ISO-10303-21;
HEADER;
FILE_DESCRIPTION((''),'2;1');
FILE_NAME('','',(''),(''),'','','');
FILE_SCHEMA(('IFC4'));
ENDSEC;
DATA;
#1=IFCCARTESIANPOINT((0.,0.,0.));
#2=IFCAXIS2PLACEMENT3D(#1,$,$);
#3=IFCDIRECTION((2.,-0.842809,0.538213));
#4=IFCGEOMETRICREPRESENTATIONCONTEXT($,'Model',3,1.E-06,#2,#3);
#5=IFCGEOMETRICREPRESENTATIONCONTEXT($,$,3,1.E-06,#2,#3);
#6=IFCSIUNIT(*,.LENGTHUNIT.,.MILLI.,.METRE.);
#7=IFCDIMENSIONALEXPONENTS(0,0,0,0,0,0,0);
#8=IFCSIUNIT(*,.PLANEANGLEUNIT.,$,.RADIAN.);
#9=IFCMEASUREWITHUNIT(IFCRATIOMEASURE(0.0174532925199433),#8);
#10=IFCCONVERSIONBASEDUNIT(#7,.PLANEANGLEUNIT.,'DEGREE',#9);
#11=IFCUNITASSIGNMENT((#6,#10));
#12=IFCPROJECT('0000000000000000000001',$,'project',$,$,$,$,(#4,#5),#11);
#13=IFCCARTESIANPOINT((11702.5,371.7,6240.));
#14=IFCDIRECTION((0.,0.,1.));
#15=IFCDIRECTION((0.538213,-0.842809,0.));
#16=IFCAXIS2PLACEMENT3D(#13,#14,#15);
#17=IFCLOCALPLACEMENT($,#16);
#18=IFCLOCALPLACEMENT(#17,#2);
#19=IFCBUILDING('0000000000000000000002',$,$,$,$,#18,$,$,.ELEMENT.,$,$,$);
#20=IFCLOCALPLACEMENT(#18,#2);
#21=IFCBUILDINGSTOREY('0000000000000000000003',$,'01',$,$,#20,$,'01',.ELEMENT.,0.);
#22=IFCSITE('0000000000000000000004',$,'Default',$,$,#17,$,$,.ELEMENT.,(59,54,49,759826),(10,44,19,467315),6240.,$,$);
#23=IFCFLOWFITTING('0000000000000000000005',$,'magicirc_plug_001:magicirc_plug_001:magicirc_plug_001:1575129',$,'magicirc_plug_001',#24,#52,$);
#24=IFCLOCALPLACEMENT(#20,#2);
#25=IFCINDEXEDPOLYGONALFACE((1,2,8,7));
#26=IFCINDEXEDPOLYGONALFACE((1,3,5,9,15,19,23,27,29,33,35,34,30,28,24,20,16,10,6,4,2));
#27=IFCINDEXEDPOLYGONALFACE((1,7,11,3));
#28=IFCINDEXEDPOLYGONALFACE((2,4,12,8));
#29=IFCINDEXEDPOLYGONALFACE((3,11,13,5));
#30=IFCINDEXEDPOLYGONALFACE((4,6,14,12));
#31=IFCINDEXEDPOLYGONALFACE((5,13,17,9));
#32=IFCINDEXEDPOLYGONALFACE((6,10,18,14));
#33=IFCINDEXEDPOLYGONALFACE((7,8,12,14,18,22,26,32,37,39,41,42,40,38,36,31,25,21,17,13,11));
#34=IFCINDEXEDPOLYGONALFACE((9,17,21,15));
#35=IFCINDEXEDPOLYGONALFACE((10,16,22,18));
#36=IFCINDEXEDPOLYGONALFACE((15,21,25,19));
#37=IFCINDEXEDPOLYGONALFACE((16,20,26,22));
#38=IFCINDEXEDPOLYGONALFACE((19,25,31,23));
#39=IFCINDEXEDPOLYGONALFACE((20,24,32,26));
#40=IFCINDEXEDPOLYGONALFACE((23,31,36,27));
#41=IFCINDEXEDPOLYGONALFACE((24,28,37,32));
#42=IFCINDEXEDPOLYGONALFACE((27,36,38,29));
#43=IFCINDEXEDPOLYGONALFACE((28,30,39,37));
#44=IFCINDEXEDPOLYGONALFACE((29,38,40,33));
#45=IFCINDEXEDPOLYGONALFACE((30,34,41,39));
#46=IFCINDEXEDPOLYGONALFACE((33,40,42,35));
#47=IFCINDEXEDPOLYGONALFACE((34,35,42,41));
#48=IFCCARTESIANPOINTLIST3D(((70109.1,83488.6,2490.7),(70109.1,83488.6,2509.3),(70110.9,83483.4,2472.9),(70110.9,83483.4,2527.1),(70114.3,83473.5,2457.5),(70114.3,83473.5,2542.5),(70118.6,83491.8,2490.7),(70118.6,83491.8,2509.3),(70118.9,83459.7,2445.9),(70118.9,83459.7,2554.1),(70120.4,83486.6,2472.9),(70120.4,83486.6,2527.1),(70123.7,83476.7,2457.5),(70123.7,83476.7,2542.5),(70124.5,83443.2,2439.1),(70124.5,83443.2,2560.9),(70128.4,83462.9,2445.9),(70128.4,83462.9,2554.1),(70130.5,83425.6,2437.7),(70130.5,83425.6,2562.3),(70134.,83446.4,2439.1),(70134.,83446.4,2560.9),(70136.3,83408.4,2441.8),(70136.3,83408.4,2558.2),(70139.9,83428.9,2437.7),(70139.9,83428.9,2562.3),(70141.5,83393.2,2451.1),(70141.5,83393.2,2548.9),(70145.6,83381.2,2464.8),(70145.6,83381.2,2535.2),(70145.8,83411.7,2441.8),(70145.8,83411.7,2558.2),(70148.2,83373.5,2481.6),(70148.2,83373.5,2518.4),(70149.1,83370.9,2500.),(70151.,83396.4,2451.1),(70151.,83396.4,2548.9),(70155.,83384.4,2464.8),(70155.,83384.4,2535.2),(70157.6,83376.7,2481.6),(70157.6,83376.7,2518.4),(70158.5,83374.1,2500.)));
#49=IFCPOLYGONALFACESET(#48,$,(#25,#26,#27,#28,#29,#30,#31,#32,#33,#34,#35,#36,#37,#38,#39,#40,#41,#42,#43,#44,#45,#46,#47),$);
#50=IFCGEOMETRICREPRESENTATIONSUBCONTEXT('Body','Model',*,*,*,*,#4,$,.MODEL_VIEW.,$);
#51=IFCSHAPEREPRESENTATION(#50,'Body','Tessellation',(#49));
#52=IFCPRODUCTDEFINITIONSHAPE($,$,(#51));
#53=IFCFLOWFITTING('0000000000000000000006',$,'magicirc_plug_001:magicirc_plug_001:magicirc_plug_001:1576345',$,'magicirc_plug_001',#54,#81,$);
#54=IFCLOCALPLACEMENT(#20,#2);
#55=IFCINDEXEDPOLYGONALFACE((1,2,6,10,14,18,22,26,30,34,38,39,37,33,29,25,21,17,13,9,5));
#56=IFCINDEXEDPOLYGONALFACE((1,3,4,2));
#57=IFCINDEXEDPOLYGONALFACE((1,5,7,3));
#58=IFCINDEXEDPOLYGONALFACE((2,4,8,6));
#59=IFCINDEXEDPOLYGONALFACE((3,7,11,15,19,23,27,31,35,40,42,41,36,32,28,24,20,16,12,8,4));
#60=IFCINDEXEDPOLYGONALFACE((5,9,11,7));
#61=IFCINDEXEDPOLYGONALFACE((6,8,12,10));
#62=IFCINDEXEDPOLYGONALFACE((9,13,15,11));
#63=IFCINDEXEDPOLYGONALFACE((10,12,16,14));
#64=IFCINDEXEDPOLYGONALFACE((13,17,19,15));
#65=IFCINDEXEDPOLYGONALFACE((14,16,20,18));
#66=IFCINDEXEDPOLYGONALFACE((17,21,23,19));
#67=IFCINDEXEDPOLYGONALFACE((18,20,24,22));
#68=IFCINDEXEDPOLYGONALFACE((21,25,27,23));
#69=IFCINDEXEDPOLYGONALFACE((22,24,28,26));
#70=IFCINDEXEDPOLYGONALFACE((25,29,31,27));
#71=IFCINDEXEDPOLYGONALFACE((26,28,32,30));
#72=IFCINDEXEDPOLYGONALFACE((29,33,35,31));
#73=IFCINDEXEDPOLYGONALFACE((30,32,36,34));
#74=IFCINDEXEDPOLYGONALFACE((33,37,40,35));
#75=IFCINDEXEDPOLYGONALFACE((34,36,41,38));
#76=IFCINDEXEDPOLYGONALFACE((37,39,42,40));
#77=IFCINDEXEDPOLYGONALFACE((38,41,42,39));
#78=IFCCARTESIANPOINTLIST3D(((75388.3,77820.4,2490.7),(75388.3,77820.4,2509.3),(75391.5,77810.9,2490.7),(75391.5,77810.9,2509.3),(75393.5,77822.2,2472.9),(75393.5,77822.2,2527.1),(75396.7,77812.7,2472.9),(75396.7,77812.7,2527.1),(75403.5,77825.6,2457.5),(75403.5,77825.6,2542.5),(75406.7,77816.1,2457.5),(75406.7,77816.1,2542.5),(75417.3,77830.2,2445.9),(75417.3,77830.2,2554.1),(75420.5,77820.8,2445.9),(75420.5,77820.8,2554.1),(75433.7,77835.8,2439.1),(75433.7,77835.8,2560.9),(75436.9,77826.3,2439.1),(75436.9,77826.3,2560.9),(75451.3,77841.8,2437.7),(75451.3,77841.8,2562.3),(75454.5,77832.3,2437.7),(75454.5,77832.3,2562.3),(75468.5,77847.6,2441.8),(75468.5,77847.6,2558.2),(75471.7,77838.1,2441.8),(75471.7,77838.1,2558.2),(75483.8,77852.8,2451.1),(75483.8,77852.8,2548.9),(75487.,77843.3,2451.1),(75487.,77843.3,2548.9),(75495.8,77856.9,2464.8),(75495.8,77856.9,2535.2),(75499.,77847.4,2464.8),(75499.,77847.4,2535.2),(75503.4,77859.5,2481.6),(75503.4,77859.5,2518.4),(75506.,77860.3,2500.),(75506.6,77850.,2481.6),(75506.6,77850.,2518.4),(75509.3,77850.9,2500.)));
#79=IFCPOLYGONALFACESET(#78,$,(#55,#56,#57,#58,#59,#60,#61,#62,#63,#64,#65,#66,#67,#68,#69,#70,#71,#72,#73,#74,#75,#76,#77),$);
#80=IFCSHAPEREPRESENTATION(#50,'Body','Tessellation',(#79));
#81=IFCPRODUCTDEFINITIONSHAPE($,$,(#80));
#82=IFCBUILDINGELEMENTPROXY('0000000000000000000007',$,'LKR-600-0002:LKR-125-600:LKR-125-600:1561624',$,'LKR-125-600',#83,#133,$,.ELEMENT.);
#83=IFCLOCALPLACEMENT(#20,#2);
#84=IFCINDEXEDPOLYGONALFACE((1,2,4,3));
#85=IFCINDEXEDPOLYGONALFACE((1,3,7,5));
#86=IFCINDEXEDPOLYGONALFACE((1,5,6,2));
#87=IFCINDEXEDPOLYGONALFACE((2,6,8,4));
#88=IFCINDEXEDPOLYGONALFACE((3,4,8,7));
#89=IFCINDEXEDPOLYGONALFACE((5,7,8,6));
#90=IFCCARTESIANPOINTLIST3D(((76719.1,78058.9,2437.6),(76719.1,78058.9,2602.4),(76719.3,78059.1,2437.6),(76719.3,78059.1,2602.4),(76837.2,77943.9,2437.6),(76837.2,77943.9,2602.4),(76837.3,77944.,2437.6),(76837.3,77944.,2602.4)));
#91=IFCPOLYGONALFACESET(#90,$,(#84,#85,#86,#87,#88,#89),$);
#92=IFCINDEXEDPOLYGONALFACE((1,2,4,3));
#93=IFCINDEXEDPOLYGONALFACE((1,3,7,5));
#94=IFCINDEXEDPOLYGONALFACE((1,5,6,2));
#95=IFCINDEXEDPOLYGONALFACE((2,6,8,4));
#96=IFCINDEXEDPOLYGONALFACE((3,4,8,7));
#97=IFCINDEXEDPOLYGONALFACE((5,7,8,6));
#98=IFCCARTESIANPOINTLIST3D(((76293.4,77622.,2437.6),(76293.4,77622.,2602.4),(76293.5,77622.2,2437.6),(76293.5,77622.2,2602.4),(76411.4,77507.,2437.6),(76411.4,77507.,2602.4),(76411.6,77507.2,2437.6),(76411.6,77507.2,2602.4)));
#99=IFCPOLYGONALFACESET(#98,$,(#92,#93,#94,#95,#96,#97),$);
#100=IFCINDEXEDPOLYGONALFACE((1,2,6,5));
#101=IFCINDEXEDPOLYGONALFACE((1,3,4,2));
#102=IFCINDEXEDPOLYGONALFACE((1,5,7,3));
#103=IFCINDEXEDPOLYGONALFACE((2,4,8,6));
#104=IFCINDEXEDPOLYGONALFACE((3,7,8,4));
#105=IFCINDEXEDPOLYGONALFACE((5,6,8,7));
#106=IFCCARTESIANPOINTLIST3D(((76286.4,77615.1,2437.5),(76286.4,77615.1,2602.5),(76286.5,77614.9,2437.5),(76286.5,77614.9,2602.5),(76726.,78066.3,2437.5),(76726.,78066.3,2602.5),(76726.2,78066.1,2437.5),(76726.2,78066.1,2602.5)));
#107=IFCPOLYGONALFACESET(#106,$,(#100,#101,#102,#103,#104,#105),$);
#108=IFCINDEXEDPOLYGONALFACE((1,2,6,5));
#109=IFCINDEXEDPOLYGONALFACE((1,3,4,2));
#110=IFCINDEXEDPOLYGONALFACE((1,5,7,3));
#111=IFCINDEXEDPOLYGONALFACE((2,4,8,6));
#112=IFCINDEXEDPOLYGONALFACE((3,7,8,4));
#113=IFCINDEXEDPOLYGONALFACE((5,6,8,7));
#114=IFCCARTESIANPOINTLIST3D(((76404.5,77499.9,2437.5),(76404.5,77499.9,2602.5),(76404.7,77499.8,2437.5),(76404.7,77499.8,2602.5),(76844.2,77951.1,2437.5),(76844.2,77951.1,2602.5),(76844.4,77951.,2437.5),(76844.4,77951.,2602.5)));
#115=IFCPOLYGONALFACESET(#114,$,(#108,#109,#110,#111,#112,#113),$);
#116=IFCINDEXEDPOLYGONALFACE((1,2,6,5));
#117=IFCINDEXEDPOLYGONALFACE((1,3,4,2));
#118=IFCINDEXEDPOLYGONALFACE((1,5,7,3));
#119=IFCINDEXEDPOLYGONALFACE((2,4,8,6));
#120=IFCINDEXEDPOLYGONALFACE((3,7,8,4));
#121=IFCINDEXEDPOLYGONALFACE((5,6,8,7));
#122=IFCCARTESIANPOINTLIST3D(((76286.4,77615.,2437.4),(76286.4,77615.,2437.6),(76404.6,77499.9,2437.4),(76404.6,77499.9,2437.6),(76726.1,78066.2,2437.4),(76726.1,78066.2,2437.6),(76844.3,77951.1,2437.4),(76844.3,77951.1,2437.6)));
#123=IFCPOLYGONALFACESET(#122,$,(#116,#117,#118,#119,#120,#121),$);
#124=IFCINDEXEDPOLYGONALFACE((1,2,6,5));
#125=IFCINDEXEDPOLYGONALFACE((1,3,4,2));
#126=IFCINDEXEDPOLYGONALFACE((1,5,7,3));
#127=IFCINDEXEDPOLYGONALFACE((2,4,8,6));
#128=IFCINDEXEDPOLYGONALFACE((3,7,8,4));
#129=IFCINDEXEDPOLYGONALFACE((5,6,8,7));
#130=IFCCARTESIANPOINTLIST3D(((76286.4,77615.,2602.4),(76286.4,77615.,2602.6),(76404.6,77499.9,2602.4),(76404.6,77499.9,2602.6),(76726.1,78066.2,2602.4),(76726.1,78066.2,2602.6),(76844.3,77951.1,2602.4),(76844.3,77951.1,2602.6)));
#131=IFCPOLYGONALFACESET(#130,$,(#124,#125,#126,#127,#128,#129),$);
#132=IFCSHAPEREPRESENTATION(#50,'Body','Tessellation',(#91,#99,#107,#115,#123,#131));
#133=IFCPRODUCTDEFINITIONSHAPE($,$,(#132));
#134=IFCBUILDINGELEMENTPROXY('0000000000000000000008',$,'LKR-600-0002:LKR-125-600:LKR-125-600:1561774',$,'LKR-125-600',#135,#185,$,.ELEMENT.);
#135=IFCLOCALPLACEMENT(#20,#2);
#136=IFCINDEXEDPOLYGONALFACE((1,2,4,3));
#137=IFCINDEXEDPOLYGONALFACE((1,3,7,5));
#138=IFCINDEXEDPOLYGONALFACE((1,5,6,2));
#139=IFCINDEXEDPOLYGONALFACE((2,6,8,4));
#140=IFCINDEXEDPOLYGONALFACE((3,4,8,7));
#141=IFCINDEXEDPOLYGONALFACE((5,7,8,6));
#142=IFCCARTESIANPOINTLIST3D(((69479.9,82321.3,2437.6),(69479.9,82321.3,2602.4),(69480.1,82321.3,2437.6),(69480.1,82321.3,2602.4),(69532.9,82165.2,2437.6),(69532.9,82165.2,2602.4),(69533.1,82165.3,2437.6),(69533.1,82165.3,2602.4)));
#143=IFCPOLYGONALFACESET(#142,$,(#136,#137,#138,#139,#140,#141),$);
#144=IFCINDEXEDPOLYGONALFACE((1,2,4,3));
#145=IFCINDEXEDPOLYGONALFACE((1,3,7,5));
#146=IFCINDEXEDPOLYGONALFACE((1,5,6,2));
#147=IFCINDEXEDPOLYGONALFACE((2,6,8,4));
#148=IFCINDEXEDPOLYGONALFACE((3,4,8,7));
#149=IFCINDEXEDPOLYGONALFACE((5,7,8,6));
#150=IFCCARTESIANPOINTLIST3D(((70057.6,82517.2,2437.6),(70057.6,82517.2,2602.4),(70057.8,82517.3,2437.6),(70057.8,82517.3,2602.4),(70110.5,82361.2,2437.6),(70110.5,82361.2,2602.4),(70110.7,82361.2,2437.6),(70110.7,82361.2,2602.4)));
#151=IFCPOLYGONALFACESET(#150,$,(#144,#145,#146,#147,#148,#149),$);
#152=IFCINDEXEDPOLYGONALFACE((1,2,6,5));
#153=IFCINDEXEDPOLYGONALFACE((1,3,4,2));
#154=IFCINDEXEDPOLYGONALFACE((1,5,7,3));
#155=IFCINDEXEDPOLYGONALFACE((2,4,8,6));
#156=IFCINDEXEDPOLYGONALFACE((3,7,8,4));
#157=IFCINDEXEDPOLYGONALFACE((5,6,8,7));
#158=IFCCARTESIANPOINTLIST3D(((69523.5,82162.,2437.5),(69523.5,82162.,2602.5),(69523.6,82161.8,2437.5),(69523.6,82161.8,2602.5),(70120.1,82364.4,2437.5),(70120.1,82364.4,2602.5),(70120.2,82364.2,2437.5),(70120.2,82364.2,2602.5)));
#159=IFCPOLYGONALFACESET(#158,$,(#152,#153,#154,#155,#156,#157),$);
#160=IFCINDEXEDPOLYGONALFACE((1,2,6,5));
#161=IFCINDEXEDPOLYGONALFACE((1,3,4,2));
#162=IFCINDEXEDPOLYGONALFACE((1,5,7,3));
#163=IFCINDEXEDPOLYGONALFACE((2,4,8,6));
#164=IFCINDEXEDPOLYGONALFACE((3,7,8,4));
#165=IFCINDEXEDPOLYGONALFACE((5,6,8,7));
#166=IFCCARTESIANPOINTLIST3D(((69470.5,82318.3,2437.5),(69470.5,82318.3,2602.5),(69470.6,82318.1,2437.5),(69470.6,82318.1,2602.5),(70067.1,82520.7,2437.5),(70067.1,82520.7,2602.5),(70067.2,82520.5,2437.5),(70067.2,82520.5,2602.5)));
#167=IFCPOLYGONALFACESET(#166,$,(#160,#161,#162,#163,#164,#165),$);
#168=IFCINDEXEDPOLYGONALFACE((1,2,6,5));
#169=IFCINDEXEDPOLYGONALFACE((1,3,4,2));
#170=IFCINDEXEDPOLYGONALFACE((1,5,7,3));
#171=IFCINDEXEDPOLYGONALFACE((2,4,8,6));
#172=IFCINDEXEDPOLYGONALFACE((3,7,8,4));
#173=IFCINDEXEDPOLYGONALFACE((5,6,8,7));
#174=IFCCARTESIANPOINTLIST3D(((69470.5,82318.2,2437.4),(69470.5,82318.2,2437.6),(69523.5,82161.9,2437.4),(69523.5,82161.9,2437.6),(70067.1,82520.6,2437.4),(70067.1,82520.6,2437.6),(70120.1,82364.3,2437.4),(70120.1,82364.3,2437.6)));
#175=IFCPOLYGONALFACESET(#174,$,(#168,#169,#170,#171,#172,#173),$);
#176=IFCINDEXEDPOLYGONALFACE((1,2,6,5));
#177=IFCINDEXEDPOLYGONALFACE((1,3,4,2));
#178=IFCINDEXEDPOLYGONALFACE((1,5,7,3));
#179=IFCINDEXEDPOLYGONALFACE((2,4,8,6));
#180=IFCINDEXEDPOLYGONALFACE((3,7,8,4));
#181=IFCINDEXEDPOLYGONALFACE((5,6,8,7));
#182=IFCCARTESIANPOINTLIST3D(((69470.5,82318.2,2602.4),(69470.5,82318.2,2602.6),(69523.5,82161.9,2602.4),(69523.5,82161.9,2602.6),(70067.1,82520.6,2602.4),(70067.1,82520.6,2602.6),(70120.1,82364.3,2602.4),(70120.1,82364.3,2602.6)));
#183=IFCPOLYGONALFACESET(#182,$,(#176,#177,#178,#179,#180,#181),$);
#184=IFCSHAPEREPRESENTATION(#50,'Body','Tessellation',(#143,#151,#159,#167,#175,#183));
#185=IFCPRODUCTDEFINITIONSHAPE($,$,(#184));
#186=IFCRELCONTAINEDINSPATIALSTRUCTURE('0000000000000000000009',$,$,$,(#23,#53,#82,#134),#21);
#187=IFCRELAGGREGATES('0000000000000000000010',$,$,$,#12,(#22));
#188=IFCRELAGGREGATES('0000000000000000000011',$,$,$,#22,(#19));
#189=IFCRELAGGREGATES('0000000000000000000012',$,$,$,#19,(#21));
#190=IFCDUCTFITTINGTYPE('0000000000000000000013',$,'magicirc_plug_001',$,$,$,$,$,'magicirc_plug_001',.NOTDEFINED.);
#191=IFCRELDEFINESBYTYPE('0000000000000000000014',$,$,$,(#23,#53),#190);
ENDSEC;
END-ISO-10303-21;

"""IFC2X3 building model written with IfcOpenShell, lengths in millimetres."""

from ifc_helpers import new_model, entity, si_unit, converted_unit, direction, frame, frame_2d, origin, place, context, subcontext, project, spatial, rectangle, circle, extrude, source, transform, mapped, type_object, type_shapes, element, save


model = new_model("IFC2X3")

# Units and contexts
model_context = context("Model", 3, precision=1e-06, world=origin(), true_north=direction((2.0, -0.842809, 0.538213)))
context_of_model = context(None, 3, precision=1e-06, world=origin(), true_north=direction((2.0, -0.842809, 0.538213)))
body_context = subcontext(model_context, "Body", "Model", "MODEL_VIEW")
ifc_project = project(units=[si_unit("LENGTHUNIT", "METRE", prefix="MILLI"), converted_unit("PLANEANGLEUNIT", "DEGREE", entity("IfcRatioMeasure", 0.0174532925199433), si_unit("PLANEANGLEUNIT", "RADIAN"), dimensions=[0, 0, 0, 0, 0, 0, 0])], contexts=[model_context, context_of_model])

# Site, building, storey
site_placement = place(None, frame((11702.5, 371.7, 6240.0), z_axis=(0.0, 0.0, 1.0), x_axis=(0.538213, -0.842809, 0.0)))
site = spatial("IfcSite", under=ifc_project, at=site_placement, Name="Default", CompositionType="ELEMENT", RefLatitude=(59, 54, 49, 759826), RefLongitude=(10, 44, 19, 467315), RefElevation=6240.0)
building_placement = place(site_placement, origin())
building = spatial("IfcBuilding", under=site, at=building_placement, CompositionType="ELEMENT")
storey_placement = place(building_placement, origin())
storey = spatial("IfcBuildingStorey", under=building, at=storey_placement, Name="01", LongName="01", CompositionType="ELEMENT", Elevation=0.0)

# Flow fittings
duct_fitting_type_1 = type_object("IfcDuctFittingType", Name="magicirc_plug_001", ElementType="magicirc_plug_001", PredefinedType="NOTDEFINED")
shared_shape_1 = source(origin(), body_context, "Body", "SweptSolid", [
    extrude(circle(Radius=62.5, at=frame_2d((0.0, 0.0), x_axis=(1.0, 0.0))), frame((0.0, 0.0, 0.0), z_axis=(1.0, 0.0, 0.0), x_axis=(0.0, 1.0, 0.0)), (0.0, 0.0, 1.0), 10.0),
])
type_shapes(duct_fitting_type_1, [shared_shape_1])
for number, where, z_axis, x_axis, name in (
    (1, (70138.4, 83433.3, 2500.0), (0.0, 0.0, 1.0), (-0.946986, -0.321274, 0.0), "magicirc_plug_001:magicirc_plug_001:magicirc_plug_001:1575129"),
    (2, (75446.9, 77840.3, 2500.0), (0.0, 0.0, 1.0), (0.321274, -0.946986, 0.0), "magicirc_plug_001:magicirc_plug_001:magicirc_plug_001:1576345"),
):
    element("IfcFlowFitting", number, at=place(storey_placement, frame(where, z_axis=z_axis, x_axis=x_axis)), inside=storey, type_object=duct_fitting_type_1, Name=name, ObjectType="magicirc_plug_001", context=body_context, shape_type="MappedRepresentation", body=[
        mapped(shared_shape_1, transform((0.0, 0.0, 0.0), scale=1.0)),
    ])

# Building element proxies
shared_shape_2 = source(origin(), body_context, "Body", "SweptSolid", [
    extrude(rectangle(XDim=0.2, YDim=164.8, at=frame_2d((0.0, 0.0), x_axis=(1.0, 0.0))), frame((305.0, 0.0, -82.4)), (0.0, 0.0, 1.0), 164.8),
    extrude(rectangle(XDim=0.2, YDim=164.8, at=frame_2d((0.0, 0.0), x_axis=(1.0, 0.0))), frame((-305.0, 0.0, -82.4)), (0.0, 0.0, 1.0), 164.8),
    extrude(rectangle(XDim=0.2, YDim=630.0, at=frame_2d((0.0, 0.0), x_axis=(1.0, 0.0))), frame((0.0, 82.5, -82.5), z_axis=(0.0, 0.0, 1.0), x_axis=(0.0, 1.0, 0.0)), (0.0, 0.0, 1.0), 165.0),
    extrude(rectangle(XDim=0.2, YDim=630.0, at=frame_2d((0.0, 0.0), x_axis=(1.0, 0.0))), frame((0.0, -82.5, -82.5), z_axis=(0.0, 0.0, 1.0), x_axis=(0.0, 1.0, 0.0)), (0.0, 0.0, 1.0), 165.0),
    extrude(rectangle(XDim=165.0, YDim=630.0, at=frame_2d((0.0, 0.0), x_axis=(1.0, 0.0))), frame((0.0, 0.0, -82.6), z_axis=(0.0, 0.0, 1.0), x_axis=(0.0, -1.0, 0.0)), (0.0, 0.0, 1.0), 0.2),
    extrude(rectangle(XDim=165.0, YDim=630.0, at=frame_2d((0.0, 0.0), x_axis=(1.0, 0.0))), frame((0.0, 0.0, 82.4), z_axis=(0.0, 0.0, 1.0), x_axis=(0.0, -1.0, 0.0)), (0.0, 0.0, 1.0), 0.2),
])
for number, where, z_axis, x_axis, name in (
    (3, (76565.4, 77783.0, 2520.0), (0.0, 0.0, 1.0), (0.697915, 0.71618, 0.0), "LKR-600-0002:LKR-125-600:LKR-125-600:1561624"),
    (4, (69795.3, 82341.3, 2520.0), (0.0, 0.0, 1.0), (-0.946986, -0.321274, 0.0), "LKR-600-0002:LKR-125-600:LKR-125-600:1561774"),
):
    element("IfcBuildingElementProxy", number, at=place(storey_placement, frame(where, z_axis=z_axis, x_axis=x_axis)), inside=storey, Name=name, ObjectType="LKR-125-600", CompositionType="ELEMENT", context=body_context, shape_type="MappedRepresentation", body=[
        mapped(shared_shape_2, transform((0.0, 0.0, 0.0), scale=1.0)),
    ])

save(model, "model.ifc")
